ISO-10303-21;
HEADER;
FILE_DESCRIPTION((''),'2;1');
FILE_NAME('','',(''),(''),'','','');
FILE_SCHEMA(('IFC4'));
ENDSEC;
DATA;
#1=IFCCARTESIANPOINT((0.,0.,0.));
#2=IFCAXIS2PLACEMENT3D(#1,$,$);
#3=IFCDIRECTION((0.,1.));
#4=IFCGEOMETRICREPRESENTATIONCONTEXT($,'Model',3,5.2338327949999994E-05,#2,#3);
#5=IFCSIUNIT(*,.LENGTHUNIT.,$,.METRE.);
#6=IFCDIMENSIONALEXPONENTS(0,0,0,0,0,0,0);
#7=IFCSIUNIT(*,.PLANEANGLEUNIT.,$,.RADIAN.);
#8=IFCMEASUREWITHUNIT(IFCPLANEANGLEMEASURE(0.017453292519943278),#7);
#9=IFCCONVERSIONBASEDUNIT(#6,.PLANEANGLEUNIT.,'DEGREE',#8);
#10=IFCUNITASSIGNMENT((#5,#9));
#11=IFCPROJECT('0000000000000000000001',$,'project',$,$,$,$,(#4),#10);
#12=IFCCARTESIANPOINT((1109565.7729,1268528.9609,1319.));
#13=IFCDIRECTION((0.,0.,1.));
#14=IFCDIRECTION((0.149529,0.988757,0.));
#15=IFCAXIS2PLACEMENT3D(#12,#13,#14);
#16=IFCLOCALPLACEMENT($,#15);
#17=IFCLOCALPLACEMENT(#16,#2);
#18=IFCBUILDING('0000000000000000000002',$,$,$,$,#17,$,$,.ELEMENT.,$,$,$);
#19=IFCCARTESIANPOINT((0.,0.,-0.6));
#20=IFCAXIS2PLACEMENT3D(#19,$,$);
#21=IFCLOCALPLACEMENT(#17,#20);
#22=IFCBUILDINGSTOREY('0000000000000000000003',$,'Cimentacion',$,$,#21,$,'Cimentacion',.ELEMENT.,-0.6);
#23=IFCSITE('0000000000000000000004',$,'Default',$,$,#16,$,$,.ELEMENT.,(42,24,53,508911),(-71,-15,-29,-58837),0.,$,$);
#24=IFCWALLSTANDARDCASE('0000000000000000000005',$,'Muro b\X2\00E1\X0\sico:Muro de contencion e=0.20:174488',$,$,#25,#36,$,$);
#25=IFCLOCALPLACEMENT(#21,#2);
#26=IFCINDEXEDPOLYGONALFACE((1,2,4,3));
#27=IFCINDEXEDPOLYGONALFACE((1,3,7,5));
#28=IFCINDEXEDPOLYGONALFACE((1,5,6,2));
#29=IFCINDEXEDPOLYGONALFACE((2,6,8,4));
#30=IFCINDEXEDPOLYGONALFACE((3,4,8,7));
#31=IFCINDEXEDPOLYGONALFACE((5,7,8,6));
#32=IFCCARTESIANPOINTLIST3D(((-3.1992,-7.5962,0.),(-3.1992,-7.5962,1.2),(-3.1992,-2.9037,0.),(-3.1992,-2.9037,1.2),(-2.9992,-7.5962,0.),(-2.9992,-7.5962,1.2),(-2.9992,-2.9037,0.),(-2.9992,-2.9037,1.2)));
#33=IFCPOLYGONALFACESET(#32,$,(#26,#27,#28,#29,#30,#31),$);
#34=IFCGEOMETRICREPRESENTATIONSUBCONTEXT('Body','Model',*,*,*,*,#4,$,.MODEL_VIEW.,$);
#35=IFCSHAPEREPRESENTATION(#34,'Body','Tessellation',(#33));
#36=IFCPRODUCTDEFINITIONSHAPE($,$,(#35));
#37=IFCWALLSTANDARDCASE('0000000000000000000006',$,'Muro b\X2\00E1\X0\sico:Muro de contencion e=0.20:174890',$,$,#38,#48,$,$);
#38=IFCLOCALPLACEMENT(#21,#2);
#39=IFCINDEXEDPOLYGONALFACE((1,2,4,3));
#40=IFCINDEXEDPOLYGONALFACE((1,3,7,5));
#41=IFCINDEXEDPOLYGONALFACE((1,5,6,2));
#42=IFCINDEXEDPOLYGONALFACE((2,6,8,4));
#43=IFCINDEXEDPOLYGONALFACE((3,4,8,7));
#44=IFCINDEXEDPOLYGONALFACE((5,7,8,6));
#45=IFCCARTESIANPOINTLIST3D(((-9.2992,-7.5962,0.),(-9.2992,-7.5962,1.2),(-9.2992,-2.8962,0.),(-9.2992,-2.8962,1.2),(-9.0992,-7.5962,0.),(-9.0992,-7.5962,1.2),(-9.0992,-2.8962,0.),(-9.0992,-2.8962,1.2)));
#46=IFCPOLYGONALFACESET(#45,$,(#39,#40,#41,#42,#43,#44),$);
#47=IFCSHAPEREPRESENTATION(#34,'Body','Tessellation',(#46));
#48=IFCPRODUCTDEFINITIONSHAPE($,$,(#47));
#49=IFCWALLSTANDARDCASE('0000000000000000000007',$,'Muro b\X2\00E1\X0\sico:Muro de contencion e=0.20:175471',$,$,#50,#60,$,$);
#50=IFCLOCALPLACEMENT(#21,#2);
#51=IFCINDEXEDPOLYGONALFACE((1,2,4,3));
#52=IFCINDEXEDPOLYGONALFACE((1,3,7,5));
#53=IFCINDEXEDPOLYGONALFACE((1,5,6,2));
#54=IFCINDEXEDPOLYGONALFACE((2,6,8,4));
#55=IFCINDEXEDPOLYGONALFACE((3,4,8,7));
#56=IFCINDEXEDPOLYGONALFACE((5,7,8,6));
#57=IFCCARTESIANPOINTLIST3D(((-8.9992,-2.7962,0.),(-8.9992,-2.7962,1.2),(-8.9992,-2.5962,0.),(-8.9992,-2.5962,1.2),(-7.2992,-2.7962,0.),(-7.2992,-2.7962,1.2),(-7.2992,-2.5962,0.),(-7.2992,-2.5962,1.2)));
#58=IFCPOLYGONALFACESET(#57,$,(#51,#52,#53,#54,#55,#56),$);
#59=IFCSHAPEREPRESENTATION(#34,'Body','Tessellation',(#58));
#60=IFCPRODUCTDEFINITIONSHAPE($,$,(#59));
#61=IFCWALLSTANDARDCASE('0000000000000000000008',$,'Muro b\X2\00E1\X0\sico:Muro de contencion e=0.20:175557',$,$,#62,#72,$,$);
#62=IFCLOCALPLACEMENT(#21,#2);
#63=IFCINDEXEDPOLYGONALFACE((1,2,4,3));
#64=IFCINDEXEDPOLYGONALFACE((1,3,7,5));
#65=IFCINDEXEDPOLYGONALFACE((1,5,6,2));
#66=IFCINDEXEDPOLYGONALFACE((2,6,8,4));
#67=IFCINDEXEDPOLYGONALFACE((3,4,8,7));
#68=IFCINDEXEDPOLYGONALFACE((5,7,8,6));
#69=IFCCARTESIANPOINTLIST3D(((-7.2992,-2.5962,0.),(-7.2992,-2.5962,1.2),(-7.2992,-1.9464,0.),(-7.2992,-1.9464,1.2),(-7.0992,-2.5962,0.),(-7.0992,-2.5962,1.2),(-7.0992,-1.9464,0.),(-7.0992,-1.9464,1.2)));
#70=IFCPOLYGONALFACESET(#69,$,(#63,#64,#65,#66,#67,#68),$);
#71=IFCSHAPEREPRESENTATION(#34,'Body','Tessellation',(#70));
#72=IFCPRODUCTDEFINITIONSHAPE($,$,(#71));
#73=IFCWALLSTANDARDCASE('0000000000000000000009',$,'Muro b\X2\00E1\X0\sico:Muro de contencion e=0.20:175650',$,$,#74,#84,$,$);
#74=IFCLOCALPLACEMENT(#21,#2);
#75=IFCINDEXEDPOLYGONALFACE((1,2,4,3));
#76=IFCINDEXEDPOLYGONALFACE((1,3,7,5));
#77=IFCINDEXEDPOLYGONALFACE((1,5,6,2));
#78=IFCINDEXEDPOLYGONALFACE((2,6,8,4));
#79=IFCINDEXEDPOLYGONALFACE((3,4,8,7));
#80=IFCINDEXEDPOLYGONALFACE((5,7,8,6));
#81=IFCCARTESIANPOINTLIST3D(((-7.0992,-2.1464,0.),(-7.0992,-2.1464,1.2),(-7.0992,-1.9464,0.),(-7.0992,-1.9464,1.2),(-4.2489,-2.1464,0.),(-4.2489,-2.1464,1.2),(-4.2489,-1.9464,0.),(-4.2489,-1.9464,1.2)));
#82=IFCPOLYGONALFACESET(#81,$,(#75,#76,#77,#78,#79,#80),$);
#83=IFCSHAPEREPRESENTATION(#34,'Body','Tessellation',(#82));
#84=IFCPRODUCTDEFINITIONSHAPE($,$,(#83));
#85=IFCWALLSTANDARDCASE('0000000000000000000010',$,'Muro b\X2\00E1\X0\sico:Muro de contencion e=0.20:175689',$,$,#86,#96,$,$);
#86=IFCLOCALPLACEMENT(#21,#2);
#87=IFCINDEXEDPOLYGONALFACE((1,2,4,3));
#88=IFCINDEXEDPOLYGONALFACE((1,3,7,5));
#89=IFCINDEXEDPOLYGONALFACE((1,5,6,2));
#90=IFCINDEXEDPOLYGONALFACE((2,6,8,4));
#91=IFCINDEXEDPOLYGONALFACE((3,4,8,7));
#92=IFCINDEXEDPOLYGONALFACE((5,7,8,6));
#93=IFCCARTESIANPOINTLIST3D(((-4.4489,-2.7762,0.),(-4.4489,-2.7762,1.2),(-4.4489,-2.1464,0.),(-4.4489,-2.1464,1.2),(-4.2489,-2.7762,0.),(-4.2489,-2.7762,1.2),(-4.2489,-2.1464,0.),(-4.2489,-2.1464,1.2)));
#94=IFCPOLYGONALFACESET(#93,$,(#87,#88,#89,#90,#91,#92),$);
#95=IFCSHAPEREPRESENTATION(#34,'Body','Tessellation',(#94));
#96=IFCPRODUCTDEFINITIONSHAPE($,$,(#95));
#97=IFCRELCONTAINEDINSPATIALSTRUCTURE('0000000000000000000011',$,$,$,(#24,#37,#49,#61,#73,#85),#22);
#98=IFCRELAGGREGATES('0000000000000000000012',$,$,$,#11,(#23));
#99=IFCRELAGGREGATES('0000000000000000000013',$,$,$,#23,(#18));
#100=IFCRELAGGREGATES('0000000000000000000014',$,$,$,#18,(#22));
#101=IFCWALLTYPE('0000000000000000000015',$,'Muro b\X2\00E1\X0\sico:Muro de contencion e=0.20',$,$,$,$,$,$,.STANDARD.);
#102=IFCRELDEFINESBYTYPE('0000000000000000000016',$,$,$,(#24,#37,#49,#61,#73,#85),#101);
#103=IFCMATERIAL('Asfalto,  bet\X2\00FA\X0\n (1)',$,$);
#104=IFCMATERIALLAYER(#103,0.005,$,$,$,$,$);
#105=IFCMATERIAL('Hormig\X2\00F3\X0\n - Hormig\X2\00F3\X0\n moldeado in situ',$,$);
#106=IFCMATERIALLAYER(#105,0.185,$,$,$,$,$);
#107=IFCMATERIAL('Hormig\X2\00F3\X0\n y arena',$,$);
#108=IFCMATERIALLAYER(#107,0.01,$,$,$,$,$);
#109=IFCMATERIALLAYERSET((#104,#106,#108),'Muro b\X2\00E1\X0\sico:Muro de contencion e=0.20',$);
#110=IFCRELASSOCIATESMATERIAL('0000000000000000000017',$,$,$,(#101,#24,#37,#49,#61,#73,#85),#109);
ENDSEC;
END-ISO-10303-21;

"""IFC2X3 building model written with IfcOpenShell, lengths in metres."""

from ifc_helpers import new_model, entity, si_unit, converted_unit, direction, frame, frame_2d, origin, place, context, subcontext, project, spatial, rectangle, extrude, material, layer, layer_set, layer_usage, type_object, element, save


model = new_model("IFC2X3")

# Units and contexts
model_context = context("Model", 3, precision=5.2338327949999994e-05, world=origin(), true_north=direction((0.0, 1.0)))
body_context = subcontext(model_context, "Body", "Model", "MODEL_VIEW")
ifc_project = project(units=[si_unit("LENGTHUNIT", "METRE"), converted_unit("PLANEANGLEUNIT", "DEGREE", entity("IfcPlaneAngleMeasure", 0.017453292519943278), si_unit("PLANEANGLEUNIT", "RADIAN"), dimensions=[0, 0, 0, 0, 0, 0, 0])], contexts=[model_context])

# Site, building, storey
site_placement = place(None, frame((1109565.7729, 1268528.9609, 1319.0), z_axis=(0.0, 0.0, 1.0), x_axis=(0.149529, 0.988757, 0.0)))
site = spatial("IfcSite", under=ifc_project, at=site_placement, Name="Default", CompositionType="ELEMENT", RefLatitude=(42, 24, 53, 508911), RefLongitude=(-71, -15, -29, -58837), RefElevation=0.0)
building_placement = place(site_placement, origin())
building = spatial("IfcBuilding", under=site, at=building_placement, CompositionType="ELEMENT")
storey_placement = place(building_placement, frame((0.0, 0.0, -0.6)))
storey = spatial("IfcBuildingStorey", under=building, at=storey_placement, Name="Cimentacion", LongName="Cimentacion", CompositionType="ELEMENT", Elevation=-0.6)

# Walls
ifc_material_1 = material(Name="Asfalto,  betún (1)")
ifc_layer_1 = layer(ifc_material_1, 0.005)
ifc_material_2 = material(Name="Hormigón - Hormigón moldeado in situ")
ifc_layer_2 = layer(ifc_material_2, 0.185)
ifc_material_3 = material(Name="Hormigón y arena")
ifc_layer_3 = layer(ifc_material_3, 0.01)
ifc_layer_set = layer_set([ifc_layer_1, ifc_layer_2, ifc_layer_3], Name="Muro básico:Muro de contencion e=0.20")
ifc_layer_usage_1 = layer_usage(ifc_layer_set, "AXIS2", "POSITIVE", -0.1)
wall_type = type_object("IfcWallType", Name="Muro básico:Muro de contencion e=0.20", PredefinedType="STANDARD", material=ifc_layer_set)
wall_1_placement = place(storey_placement, frame((-3.0992, -7.5962, 0.0), z_axis=(0.0, 0.0, 1.0), x_axis=(0.0, 1.0, 0.0)))
element("IfcWallStandardCase", 1, at=wall_1_placement, inside=storey, type_object=wall_type, material=ifc_layer_usage_1, Name="Muro básico:Muro de contencion e=0.20:174488", context=body_context, shape_type="SweptSolid", body=[
    extrude(rectangle(XDim=4.6925, YDim=0.2, at=frame_2d((2.3462, 0.0), x_axis=(-1.0, 0.0))), origin(), (0.0, 0.0, 1.0), 1.2),
])
ifc_layer_usage_2 = layer_usage(ifc_layer_set, "AXIS2", "NEGATIVE", 0.1)
wall_2_placement = place(storey_placement, frame((-9.1992, -7.5962, 0.0), z_axis=(0.0, 0.0, 1.0), x_axis=(0.0, 1.0, 0.0)))
element("IfcWallStandardCase", 2, at=wall_2_placement, inside=storey, type_object=wall_type, material=ifc_layer_usage_2, Name="Muro básico:Muro de contencion e=0.20:174890", context=body_context, shape_type="SweptSolid", body=[
    extrude(rectangle(XDim=4.7, YDim=0.2, at=frame_2d((2.35, 0.0), x_axis=(-1.0, 0.0))), origin(), (0.0, 0.0, 1.0), 1.2),
])
ifc_layer_usage_3 = layer_usage(ifc_layer_set, "AXIS2", "NEGATIVE", 0.1)
wall_3_placement = place(storey_placement, frame((-8.9992, -2.6962, 0.0)))
element("IfcWallStandardCase", 3, at=wall_3_placement, inside=storey, type_object=wall_type, material=ifc_layer_usage_3, Name="Muro básico:Muro de contencion e=0.20:175471", context=body_context, shape_type="SweptSolid", body=[
    extrude(rectangle(XDim=1.7, YDim=0.2, at=frame_2d((0.85, 0.0), x_axis=(-1.0, 0.0))), origin(), (0.0, 0.0, 1.0), 1.2),
])
ifc_layer_usage_4 = layer_usage(ifc_layer_set, "AXIS2", "NEGATIVE", 0.1)
wall_4_placement = place(storey_placement, frame((-7.1992, -2.5962, 0.0), z_axis=(0.0, 0.0, 1.0), x_axis=(0.0, 1.0, 0.0)))
element("IfcWallStandardCase", 4, at=wall_4_placement, inside=storey, type_object=wall_type, material=ifc_layer_usage_4, Name="Muro básico:Muro de contencion e=0.20:175557", context=body_context, shape_type="SweptSolid", body=[
    extrude(rectangle(XDim=0.6498, YDim=0.2, at=frame_2d((0.3249, 0.0), x_axis=(-1.0, 0.0))), origin(), (0.0, 0.0, 1.0), 1.2),
])
ifc_layer_usage_5 = layer_usage(ifc_layer_set, "AXIS2", "NEGATIVE", 0.1)
wall_5_placement = place(storey_placement, frame((-7.0992, -2.0464, 0.0)))
element("IfcWallStandardCase", 5, at=wall_5_placement, inside=storey, type_object=wall_type, material=ifc_layer_usage_5, Name="Muro básico:Muro de contencion e=0.20:175650", context=body_context, shape_type="SweptSolid", body=[
    extrude(rectangle(XDim=2.8504, YDim=0.2, at=frame_2d((1.4252, 0.0), x_axis=(-1.0, 0.0))), origin(), (0.0, 0.0, 1.0), 1.2),
])
ifc_layer_usage_6 = layer_usage(ifc_layer_set, "AXIS2", "NEGATIVE", 0.1)
wall_6_placement = place(storey_placement, frame((-4.3489, -2.1464, 0.0), z_axis=(0.0, 0.0, 1.0), x_axis=(0.0, -1.0, 0.0)))
element("IfcWallStandardCase", 6, at=wall_6_placement, inside=storey, type_object=wall_type, material=ifc_layer_usage_6, Name="Muro básico:Muro de contencion e=0.20:175689", context=body_context, shape_type="SweptSolid", body=[
    extrude(rectangle(XDim=0.6298, YDim=0.2, at=frame_2d((0.3149, 0.0), x_axis=(-1.0, 0.0))), origin(), (0.0, 0.0, 1.0), 1.2),
])

save(model, "model.ifc")
